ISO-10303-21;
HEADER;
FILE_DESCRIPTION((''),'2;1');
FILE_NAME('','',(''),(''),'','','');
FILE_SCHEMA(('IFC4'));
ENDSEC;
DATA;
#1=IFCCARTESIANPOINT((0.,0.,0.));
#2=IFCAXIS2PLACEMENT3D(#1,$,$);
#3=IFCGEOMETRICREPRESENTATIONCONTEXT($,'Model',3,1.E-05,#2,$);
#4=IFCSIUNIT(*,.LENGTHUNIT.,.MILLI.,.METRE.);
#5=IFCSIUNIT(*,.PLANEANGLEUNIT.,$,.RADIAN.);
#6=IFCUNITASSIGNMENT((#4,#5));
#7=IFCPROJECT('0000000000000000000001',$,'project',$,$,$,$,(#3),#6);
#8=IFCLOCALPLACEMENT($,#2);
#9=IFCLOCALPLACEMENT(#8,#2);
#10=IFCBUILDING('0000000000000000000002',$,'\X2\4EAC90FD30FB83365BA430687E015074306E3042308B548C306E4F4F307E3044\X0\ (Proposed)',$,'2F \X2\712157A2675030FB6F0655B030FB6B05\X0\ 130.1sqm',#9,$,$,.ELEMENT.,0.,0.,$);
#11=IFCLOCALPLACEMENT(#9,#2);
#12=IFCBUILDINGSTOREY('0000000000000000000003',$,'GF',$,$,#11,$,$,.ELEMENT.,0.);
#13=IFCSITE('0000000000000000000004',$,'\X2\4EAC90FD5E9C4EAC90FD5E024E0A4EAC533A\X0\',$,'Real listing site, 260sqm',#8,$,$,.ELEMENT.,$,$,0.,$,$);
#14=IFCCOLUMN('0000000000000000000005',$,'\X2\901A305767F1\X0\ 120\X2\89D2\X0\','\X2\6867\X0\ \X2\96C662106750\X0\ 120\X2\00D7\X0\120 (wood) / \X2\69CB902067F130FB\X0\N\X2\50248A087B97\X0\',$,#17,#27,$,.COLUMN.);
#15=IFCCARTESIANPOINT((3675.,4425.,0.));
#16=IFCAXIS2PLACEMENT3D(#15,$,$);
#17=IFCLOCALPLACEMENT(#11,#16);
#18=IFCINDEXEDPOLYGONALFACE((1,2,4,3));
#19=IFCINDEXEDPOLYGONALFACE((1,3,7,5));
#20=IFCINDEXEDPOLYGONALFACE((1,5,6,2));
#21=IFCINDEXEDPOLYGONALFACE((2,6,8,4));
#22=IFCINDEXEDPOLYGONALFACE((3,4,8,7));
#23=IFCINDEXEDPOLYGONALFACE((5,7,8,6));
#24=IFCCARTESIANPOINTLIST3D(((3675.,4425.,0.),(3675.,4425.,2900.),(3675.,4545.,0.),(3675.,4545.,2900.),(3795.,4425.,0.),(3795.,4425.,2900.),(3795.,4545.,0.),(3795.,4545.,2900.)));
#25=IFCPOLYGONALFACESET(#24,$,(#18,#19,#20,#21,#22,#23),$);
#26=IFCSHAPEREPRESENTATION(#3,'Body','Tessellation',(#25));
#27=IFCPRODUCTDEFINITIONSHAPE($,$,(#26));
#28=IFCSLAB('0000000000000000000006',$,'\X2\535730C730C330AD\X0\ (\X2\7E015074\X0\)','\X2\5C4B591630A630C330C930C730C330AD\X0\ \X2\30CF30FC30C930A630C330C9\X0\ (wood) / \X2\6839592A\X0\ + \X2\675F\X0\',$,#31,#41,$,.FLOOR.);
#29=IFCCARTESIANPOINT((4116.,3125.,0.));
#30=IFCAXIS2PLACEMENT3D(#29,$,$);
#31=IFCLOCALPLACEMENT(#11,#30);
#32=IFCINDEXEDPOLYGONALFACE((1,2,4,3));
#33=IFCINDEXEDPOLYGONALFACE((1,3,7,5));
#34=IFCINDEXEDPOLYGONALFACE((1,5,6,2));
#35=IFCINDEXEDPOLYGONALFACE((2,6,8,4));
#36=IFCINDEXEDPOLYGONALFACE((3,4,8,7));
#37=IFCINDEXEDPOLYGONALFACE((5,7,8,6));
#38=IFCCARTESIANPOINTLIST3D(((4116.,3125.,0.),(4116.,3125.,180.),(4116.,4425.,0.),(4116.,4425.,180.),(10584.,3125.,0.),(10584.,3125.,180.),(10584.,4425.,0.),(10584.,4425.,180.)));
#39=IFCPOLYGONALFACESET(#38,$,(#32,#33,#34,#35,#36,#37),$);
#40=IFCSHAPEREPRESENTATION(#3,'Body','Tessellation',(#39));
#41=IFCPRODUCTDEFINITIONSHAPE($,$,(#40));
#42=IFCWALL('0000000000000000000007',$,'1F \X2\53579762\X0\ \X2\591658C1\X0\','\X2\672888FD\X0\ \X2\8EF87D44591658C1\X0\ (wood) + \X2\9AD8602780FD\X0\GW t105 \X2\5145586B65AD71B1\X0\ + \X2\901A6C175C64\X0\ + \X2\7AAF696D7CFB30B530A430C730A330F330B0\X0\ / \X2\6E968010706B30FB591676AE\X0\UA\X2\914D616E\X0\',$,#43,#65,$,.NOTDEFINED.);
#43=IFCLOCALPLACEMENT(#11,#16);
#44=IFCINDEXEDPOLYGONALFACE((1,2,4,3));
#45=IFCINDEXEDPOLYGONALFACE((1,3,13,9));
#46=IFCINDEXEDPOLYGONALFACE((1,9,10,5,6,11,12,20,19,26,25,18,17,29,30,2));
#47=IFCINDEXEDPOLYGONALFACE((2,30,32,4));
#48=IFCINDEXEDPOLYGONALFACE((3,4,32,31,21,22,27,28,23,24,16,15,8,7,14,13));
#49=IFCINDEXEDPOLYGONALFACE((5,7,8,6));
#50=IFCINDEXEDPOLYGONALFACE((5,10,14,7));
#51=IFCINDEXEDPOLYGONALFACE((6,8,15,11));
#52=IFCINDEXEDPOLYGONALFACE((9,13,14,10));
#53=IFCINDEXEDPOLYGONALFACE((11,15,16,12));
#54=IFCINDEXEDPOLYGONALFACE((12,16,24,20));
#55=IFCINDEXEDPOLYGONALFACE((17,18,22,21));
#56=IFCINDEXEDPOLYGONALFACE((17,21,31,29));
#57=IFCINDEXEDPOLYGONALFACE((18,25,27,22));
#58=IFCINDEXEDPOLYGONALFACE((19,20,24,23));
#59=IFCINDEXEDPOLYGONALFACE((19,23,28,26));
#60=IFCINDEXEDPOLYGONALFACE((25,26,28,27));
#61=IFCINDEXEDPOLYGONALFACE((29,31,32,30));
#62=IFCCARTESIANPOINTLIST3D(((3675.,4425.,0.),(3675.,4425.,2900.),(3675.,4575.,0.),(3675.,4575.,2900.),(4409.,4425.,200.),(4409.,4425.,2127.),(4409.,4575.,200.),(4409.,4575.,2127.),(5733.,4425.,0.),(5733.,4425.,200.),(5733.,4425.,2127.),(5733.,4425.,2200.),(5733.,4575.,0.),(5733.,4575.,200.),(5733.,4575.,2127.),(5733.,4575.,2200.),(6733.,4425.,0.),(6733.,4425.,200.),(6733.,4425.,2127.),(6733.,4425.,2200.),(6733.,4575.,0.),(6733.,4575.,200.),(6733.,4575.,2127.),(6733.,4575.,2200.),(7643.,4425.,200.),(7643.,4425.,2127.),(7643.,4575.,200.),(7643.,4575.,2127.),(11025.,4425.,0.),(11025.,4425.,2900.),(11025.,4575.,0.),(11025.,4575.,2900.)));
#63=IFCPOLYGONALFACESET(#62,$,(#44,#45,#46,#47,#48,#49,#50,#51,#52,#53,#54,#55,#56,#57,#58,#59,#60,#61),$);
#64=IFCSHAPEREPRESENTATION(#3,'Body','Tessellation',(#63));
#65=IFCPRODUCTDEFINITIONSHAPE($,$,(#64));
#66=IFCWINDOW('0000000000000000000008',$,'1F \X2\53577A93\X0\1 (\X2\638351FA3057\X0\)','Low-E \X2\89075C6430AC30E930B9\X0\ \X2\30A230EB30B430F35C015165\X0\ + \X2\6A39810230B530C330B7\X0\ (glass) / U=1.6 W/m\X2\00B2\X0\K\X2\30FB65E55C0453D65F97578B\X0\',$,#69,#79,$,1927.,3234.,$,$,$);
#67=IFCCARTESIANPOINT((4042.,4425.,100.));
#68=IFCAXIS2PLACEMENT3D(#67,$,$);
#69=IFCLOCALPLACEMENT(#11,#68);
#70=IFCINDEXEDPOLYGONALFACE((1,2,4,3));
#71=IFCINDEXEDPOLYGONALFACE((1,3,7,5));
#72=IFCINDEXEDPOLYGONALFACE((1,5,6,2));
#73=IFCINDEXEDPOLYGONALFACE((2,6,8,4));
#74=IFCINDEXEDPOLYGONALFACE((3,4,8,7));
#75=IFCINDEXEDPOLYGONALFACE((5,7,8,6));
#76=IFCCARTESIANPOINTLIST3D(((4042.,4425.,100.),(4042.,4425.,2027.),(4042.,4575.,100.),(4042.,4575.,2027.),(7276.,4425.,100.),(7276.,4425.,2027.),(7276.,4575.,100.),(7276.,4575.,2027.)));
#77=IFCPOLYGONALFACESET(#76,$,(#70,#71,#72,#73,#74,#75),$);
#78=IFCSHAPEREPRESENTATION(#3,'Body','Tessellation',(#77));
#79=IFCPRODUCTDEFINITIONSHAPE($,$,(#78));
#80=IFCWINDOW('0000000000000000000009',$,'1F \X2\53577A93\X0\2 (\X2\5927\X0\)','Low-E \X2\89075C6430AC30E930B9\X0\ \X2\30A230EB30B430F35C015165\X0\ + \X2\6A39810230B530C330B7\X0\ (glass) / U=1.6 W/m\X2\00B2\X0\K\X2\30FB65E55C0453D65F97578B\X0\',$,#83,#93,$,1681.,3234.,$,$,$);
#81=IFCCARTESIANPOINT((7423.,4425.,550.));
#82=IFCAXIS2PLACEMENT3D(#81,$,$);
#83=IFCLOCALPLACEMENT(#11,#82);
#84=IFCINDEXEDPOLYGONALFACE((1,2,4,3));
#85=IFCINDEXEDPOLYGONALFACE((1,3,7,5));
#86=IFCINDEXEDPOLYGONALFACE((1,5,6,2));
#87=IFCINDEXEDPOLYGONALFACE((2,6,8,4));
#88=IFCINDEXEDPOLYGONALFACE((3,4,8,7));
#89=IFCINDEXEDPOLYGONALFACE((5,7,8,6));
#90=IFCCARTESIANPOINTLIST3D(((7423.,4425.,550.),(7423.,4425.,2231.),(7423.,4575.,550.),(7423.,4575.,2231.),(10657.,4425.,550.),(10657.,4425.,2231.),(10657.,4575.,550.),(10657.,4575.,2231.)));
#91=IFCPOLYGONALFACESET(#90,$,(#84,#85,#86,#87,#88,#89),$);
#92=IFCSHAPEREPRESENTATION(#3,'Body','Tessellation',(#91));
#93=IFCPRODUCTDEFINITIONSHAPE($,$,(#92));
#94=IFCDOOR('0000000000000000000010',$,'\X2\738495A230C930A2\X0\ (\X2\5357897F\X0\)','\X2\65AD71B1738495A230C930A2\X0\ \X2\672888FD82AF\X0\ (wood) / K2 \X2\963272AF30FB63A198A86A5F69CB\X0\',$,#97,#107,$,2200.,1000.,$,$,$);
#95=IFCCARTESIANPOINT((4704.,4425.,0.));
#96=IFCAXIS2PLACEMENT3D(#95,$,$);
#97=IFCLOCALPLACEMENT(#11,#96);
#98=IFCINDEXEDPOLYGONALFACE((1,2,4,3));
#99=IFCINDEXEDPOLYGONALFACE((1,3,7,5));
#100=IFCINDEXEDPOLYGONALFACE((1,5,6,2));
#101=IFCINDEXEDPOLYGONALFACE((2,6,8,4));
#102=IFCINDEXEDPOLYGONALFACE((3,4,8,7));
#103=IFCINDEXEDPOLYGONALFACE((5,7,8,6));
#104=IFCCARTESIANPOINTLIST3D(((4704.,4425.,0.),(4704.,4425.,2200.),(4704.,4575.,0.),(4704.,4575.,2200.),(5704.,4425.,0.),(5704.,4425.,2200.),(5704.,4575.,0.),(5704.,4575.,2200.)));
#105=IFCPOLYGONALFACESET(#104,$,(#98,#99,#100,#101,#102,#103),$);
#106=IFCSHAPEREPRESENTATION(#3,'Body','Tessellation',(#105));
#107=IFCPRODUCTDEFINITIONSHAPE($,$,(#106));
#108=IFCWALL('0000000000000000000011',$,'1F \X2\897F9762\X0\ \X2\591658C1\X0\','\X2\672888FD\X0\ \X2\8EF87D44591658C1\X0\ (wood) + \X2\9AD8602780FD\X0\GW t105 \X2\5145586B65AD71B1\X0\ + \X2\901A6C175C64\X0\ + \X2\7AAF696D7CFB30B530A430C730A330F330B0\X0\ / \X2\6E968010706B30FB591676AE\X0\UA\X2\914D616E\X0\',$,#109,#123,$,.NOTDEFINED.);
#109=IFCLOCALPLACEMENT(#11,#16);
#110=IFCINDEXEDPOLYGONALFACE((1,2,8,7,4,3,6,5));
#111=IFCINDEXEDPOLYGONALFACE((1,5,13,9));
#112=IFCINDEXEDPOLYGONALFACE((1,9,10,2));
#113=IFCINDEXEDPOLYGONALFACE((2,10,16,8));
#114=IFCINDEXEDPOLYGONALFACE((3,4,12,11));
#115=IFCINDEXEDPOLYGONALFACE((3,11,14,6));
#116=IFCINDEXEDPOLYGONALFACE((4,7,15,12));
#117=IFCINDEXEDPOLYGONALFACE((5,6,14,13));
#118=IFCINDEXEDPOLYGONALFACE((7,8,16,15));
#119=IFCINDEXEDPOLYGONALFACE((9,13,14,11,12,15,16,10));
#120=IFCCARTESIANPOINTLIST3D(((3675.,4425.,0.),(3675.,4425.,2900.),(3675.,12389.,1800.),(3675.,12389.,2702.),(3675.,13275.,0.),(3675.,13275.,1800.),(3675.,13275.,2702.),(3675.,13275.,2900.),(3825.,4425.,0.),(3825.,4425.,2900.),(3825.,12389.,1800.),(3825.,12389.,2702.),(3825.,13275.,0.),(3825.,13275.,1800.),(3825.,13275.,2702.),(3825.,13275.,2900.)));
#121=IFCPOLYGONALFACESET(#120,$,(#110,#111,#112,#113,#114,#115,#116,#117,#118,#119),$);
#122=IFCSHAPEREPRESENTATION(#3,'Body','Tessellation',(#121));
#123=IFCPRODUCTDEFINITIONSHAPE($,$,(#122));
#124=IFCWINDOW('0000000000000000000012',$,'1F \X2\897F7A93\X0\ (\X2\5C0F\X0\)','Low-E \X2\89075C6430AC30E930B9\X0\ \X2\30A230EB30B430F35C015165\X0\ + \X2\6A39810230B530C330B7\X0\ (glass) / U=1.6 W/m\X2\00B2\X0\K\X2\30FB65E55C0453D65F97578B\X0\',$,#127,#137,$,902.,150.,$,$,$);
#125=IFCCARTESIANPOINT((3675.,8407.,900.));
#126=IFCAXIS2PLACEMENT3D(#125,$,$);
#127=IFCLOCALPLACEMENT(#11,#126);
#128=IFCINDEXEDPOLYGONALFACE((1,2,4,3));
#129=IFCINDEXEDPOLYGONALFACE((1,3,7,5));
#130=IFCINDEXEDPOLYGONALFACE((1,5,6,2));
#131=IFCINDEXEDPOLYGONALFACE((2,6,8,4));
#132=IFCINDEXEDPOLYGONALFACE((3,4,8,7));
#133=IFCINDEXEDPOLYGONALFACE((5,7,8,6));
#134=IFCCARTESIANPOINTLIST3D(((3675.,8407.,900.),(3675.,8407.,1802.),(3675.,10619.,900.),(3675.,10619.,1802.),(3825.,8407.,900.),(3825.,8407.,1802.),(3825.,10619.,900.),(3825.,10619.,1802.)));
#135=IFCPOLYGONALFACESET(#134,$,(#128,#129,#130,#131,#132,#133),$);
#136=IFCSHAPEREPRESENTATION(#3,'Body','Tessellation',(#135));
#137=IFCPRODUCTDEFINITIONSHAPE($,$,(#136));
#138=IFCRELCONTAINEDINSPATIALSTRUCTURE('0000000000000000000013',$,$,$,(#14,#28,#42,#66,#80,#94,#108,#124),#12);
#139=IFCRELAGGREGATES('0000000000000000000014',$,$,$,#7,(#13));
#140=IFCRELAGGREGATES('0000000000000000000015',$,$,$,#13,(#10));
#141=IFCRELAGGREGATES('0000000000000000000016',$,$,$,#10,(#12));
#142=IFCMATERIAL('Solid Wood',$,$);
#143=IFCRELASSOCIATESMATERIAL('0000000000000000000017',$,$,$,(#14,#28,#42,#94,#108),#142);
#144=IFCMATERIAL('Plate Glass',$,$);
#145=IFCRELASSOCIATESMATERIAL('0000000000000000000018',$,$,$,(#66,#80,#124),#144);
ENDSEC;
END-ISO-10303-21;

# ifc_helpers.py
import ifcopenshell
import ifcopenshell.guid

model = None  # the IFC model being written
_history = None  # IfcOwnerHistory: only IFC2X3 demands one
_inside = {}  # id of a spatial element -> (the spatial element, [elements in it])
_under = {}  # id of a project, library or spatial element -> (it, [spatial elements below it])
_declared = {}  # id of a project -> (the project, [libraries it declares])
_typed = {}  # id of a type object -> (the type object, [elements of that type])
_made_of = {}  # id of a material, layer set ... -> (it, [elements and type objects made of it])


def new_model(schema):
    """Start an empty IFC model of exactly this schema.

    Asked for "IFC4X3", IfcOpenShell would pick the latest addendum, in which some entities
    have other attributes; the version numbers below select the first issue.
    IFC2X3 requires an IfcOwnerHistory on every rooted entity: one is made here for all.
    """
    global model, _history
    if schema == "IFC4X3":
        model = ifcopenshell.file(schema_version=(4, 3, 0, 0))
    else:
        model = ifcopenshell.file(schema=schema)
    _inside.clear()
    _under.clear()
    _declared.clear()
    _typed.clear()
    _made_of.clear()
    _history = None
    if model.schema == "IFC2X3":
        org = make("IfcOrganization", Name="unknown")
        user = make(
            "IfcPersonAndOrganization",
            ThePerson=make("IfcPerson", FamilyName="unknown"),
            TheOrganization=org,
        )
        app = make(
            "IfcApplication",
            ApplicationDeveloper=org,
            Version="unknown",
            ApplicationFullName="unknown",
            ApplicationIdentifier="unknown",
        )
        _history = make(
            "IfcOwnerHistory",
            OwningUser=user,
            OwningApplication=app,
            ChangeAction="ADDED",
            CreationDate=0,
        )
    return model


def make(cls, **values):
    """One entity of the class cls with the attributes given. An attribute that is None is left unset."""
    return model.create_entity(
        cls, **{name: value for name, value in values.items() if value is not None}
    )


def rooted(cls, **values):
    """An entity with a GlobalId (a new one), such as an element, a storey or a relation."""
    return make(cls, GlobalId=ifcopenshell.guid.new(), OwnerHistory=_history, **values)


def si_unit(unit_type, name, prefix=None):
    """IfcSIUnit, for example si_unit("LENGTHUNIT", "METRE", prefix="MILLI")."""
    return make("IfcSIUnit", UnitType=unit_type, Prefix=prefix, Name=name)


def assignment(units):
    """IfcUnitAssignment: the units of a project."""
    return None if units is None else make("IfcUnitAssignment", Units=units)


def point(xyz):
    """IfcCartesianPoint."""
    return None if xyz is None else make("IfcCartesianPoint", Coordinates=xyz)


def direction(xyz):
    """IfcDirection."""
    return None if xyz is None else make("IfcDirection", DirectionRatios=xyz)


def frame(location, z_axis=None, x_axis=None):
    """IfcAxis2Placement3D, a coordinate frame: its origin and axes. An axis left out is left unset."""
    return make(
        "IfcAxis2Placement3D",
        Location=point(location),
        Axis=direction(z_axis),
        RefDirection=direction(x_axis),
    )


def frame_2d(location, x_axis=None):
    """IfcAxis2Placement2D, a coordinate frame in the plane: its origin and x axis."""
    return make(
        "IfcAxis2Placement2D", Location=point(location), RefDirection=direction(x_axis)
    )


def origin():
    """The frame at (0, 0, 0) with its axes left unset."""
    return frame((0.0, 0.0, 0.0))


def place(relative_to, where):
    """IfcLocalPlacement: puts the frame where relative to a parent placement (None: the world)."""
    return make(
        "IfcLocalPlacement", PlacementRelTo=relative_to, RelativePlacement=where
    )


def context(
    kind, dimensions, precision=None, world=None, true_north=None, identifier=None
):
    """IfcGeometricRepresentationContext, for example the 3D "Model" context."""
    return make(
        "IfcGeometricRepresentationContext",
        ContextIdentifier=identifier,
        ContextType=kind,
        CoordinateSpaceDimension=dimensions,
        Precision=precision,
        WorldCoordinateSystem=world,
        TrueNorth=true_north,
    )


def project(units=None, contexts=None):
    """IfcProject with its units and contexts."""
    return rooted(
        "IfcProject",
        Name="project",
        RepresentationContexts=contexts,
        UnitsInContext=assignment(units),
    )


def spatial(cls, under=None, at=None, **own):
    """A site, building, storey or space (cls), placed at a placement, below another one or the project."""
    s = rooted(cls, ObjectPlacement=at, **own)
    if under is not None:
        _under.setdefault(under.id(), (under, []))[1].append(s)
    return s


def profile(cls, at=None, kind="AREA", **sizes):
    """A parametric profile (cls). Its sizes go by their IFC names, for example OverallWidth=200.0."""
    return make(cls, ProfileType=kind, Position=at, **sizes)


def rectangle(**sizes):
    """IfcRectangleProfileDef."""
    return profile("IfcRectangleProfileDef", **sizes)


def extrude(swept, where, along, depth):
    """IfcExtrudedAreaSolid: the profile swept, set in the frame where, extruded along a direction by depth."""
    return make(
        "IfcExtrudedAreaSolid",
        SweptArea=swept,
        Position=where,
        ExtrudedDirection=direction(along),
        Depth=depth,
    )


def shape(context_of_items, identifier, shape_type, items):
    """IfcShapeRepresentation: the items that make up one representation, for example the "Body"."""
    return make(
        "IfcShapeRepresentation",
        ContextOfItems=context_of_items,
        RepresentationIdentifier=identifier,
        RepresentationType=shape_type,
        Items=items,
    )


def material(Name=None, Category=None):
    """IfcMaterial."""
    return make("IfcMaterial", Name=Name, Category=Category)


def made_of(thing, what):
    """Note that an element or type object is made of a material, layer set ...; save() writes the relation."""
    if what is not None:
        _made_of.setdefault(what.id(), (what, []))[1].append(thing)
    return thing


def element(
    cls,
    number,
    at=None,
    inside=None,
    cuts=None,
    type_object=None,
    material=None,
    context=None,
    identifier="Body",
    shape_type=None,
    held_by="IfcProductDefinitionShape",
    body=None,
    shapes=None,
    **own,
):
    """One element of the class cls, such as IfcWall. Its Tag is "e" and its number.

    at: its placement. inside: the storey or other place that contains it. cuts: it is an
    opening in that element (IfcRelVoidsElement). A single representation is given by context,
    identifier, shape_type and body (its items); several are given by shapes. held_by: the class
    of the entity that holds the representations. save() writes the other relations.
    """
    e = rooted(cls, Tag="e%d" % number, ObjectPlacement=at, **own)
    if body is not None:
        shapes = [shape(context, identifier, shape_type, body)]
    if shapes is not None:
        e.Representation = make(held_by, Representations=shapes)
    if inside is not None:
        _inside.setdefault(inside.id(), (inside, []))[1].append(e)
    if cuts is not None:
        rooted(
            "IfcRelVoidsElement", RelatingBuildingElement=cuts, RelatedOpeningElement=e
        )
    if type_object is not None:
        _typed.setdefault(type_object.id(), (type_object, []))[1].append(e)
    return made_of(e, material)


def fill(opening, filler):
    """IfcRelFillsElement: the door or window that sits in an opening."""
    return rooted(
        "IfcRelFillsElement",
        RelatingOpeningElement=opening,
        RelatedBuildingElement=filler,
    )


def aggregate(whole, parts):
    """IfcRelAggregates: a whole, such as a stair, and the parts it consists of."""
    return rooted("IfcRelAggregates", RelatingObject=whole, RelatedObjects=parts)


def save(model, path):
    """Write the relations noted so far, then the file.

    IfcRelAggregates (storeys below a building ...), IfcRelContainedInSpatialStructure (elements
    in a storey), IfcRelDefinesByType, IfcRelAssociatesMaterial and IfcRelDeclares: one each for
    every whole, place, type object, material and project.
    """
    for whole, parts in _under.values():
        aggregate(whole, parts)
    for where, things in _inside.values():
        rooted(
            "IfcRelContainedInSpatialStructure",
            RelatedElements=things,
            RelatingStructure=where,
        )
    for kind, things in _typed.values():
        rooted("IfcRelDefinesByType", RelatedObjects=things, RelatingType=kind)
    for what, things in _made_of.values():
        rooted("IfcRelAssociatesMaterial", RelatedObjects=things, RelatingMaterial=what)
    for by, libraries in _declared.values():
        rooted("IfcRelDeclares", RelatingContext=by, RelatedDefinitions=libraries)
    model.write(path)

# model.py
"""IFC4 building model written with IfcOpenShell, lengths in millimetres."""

from ifc_helpers import new_model, si_unit, frame, frame_2d, origin, place, context, project, spatial, rectangle, extrude, material, element, fill, save


model = new_model("IFC4")

# Units and contexts
model_context = context("Model", 3, precision=1e-05, world=origin())
ifc_project = project(units=[si_unit("LENGTHUNIT", "METRE", prefix="MILLI"), si_unit("PLANEANGLEUNIT", "RADIAN")], contexts=[model_context])

# Site, building, storey
site_placement = place(None, origin())
site = spatial("IfcSite", under=ifc_project, at=site_placement, Name="京都府京都市上京区", ObjectType="Real listing site, 260sqm", CompositionType="ELEMENT", RefElevation=0.0)
building_placement = place(site_placement, origin())
building = spatial("IfcBuilding", under=site, at=building_placement, Name="京都・茶室と縁側のある和の住まい (Proposed)", ObjectType="2F 無垢材・漆喰・欅 130.1sqm", CompositionType="ELEMENT", ElevationOfRefHeight=0.0, ElevationOfTerrain=0.0)
storey_placement = place(building_placement, origin())
storey = spatial("IfcBuildingStorey", under=building, at=storey_placement, Name="GF", CompositionType="ELEMENT", Elevation=0.0)

# Column
ifc_material_1 = material(Name="Solid Wood")
column_placement = place(storey_placement, frame((3675.0, 4425.0, 0.0)))
element("IfcColumn", 1, at=column_placement, inside=storey, material=ifc_material_1, Name="通し柱 120角", Description="桧 集成材 120×120 (wood) / 構造柱・N値計算", PredefinedType="COLUMN", context=model_context, shape_type="SweptSolid", body=[
    extrude(rectangle(XDim=120.0, YDim=120.0, at=frame_2d((60.0, 60.0))), frame((3675.0, 4425.0, 0.0)), (0.0, 0.0, 1.0), 2900.0),
])

# Slab
slab_1_placement = place(storey_placement, frame((4116.0, 3125.0, 0.0)))
element("IfcSlab", 2, at=slab_1_placement, inside=storey, material=ifc_material_1, Name="南デッキ (縁側)", Description="屋外ウッドデッキ ハードウッド (wood) / 根太 + 束", PredefinedType="FLOOR", context=model_context, shape_type="SweptSolid", body=[
    extrude(rectangle(XDim=6468.0, YDim=1300.0, at=frame_2d((3234.0, 650.0))), frame((4116.0, 3125.0, 0.0)), (0.0, 0.0, 1.0), 180.0),
])

# Wall, openings, windows, door
wall_1_placement = place(storey_placement, frame((3675.0, 4425.0, 0.0)))
wall_1 = element("IfcWall", 3, at=wall_1_placement, inside=storey, material=ifc_material_1, Name="1F 南面 外壁", Description="木製 軸組外壁 (wood) + 高性能GW t105 充填断熱 + 通気層 + 窯業系サイディング / 準耐火・外皮UA配慮", PredefinedType="NOTDEFINED", context=model_context, shape_type="SweptSolid", body=[
    extrude(rectangle(XDim=7350.0, YDim=150.0, at=frame_2d((3675.0, 75.0))), frame((3675.0, 4425.0, 0.0)), (0.0, 0.0, 1.0), 2900.0),
])
opening_1_placement = place(storey_placement, frame((4042.0, 4425.0, 100.0)))
opening_1 = element("IfcOpeningElement", 4, at=opening_1_placement, cuts=wall_1, PredefinedType="NOTDEFINED", context=model_context, shape_type="SweptSolid", body=[
    extrude(rectangle(XDim=3234.0, YDim=150.0, at=frame_2d((1617.0, 75.0))), frame((4042.0, 4425.0, 100.0)), (0.0, 0.0, 1.0), 1927.0),
])
opening_2_placement = place(storey_placement, frame((7423.0, 4425.0, 550.0)))
opening_2 = element("IfcOpeningElement", 5, at=opening_2_placement, cuts=wall_1, PredefinedType="NOTDEFINED", context=model_context, shape_type="SweptSolid", body=[
    extrude(rectangle(XDim=3234.0, YDim=150.0, at=frame_2d((1617.0, 75.0))), frame((7423.0, 4425.0, 550.0)), (0.0, 0.0, 1.0), 1681.0),
])
opening_3_placement = place(storey_placement, frame((4704.0, 4425.0, 0.0)))
opening_3 = element("IfcOpeningElement", 6, at=opening_3_placement, cuts=wall_1, PredefinedType="NOTDEFINED", context=model_context, shape_type="SweptSolid", body=[
    extrude(rectangle(XDim=1000.0, YDim=150.0, at=frame_2d((500.0, 75.0))), frame((4704.0, 4425.0, 0.0)), (0.0, 0.0, 1.0), 2200.0),
])
ifc_material_2 = material(Name="Plate Glass")
window_1_placement = place(storey_placement, frame((4042.0, 4425.0, 100.0)))
window_1 = element("IfcWindow", 7, at=window_1_placement, inside=storey, material=ifc_material_2, Name="1F 南窓1 (掃出し)", Description="Low-E 複層ガラス アルゴン封入 + 樹脂サッシ (glass) / U=1.6 W/m²K・日射取得型", OverallHeight=1927.0, OverallWidth=3234.0, context=model_context, shape_type="SweptSolid", body=[
    extrude(rectangle(XDim=3234.0, YDim=150.0, at=frame_2d((1617.0, 75.0))), frame((4042.0, 4425.0, 100.0)), (0.0, 0.0, 1.0), 1927.0),
])
fill(opening_1, window_1)
window_2_placement = place(storey_placement, frame((7423.0, 4425.0, 550.0)))
window_2 = element("IfcWindow", 8, at=window_2_placement, inside=storey, material=ifc_material_2, Name="1F 南窓2 (大)", Description="Low-E 複層ガラス アルゴン封入 + 樹脂サッシ (glass) / U=1.6 W/m²K・日射取得型", OverallHeight=1681.0, OverallWidth=3234.0, context=model_context, shape_type="SweptSolid", body=[
    extrude(rectangle(XDim=3234.0, YDim=150.0, at=frame_2d((1617.0, 75.0))), frame((7423.0, 4425.0, 550.0)), (0.0, 0.0, 1.0), 1681.0),
])
fill(opening_2, window_2)
door_placement = place(storey_placement, frame((4704.0, 4425.0, 0.0)))
door = element("IfcDoor", 9, at=door_placement, inside=storey, material=ifc_material_1, Name="玄関ドア (南西)", Description="断熱玄関ドア 木製芯 (wood) / K2 防犯・採風機構", OverallHeight=2200.0, OverallWidth=1000.0, context=model_context, shape_type="SweptSolid", body=[
    extrude(rectangle(XDim=1000.0, YDim=150.0, at=frame_2d((500.0, 75.0))), frame((4704.0, 4425.0, 0.0)), (0.0, 0.0, 1.0), 2200.0),
])
fill(opening_3, door)

# Wall, opening, window
wall_2_placement = place(storey_placement, frame((3675.0, 4425.0, 0.0)))
wall_2 = element("IfcWall", 10, at=wall_2_placement, inside=storey, material=ifc_material_1, Name="1F 西面 外壁", Description="木製 軸組外壁 (wood) + 高性能GW t105 充填断熱 + 通気層 + 窯業系サイディング / 準耐火・外皮UA配慮", PredefinedType="NOTDEFINED", context=model_context, shape_type="SweptSolid", body=[
    extrude(rectangle(XDim=150.0, YDim=8850.0, at=frame_2d((75.0, 4425.0))), frame((3675.0, 4425.0, 0.0)), (0.0, 0.0, 1.0), 2900.0),
])
opening_4_placement = place(storey_placement, frame((3675.0, 8407.0, 900.0)))
opening_4 = element("IfcOpeningElement", 11, at=opening_4_placement, cuts=wall_2, PredefinedType="NOTDEFINED", context=model_context, shape_type="SweptSolid", body=[
    extrude(rectangle(XDim=150.0, YDim=2212.0, at=frame_2d((75.0, 1106.0))), frame((3675.0, 8407.0, 900.0)), (0.0, 0.0, 1.0), 902.0),
])
window_3_placement = place(storey_placement, frame((3675.0, 8407.0, 900.0)))
window_3 = element("IfcWindow", 12, at=window_3_placement, inside=storey, material=ifc_material_2, Name="1F 西窓 (小)", Description="Low-E 複層ガラス アルゴン封入 + 樹脂サッシ (glass) / U=1.6 W/m²K・日射取得型", OverallHeight=902.0, OverallWidth=150.0, context=model_context, shape_type="SweptSolid", body=[
    extrude(rectangle(XDim=150.0, YDim=2212.0, at=frame_2d((75.0, 1106.0))), frame((3675.0, 8407.0, 900.0)), (0.0, 0.0, 1.0), 902.0),
])
fill(opening_4, window_3)

save(model, "model.ifc")
